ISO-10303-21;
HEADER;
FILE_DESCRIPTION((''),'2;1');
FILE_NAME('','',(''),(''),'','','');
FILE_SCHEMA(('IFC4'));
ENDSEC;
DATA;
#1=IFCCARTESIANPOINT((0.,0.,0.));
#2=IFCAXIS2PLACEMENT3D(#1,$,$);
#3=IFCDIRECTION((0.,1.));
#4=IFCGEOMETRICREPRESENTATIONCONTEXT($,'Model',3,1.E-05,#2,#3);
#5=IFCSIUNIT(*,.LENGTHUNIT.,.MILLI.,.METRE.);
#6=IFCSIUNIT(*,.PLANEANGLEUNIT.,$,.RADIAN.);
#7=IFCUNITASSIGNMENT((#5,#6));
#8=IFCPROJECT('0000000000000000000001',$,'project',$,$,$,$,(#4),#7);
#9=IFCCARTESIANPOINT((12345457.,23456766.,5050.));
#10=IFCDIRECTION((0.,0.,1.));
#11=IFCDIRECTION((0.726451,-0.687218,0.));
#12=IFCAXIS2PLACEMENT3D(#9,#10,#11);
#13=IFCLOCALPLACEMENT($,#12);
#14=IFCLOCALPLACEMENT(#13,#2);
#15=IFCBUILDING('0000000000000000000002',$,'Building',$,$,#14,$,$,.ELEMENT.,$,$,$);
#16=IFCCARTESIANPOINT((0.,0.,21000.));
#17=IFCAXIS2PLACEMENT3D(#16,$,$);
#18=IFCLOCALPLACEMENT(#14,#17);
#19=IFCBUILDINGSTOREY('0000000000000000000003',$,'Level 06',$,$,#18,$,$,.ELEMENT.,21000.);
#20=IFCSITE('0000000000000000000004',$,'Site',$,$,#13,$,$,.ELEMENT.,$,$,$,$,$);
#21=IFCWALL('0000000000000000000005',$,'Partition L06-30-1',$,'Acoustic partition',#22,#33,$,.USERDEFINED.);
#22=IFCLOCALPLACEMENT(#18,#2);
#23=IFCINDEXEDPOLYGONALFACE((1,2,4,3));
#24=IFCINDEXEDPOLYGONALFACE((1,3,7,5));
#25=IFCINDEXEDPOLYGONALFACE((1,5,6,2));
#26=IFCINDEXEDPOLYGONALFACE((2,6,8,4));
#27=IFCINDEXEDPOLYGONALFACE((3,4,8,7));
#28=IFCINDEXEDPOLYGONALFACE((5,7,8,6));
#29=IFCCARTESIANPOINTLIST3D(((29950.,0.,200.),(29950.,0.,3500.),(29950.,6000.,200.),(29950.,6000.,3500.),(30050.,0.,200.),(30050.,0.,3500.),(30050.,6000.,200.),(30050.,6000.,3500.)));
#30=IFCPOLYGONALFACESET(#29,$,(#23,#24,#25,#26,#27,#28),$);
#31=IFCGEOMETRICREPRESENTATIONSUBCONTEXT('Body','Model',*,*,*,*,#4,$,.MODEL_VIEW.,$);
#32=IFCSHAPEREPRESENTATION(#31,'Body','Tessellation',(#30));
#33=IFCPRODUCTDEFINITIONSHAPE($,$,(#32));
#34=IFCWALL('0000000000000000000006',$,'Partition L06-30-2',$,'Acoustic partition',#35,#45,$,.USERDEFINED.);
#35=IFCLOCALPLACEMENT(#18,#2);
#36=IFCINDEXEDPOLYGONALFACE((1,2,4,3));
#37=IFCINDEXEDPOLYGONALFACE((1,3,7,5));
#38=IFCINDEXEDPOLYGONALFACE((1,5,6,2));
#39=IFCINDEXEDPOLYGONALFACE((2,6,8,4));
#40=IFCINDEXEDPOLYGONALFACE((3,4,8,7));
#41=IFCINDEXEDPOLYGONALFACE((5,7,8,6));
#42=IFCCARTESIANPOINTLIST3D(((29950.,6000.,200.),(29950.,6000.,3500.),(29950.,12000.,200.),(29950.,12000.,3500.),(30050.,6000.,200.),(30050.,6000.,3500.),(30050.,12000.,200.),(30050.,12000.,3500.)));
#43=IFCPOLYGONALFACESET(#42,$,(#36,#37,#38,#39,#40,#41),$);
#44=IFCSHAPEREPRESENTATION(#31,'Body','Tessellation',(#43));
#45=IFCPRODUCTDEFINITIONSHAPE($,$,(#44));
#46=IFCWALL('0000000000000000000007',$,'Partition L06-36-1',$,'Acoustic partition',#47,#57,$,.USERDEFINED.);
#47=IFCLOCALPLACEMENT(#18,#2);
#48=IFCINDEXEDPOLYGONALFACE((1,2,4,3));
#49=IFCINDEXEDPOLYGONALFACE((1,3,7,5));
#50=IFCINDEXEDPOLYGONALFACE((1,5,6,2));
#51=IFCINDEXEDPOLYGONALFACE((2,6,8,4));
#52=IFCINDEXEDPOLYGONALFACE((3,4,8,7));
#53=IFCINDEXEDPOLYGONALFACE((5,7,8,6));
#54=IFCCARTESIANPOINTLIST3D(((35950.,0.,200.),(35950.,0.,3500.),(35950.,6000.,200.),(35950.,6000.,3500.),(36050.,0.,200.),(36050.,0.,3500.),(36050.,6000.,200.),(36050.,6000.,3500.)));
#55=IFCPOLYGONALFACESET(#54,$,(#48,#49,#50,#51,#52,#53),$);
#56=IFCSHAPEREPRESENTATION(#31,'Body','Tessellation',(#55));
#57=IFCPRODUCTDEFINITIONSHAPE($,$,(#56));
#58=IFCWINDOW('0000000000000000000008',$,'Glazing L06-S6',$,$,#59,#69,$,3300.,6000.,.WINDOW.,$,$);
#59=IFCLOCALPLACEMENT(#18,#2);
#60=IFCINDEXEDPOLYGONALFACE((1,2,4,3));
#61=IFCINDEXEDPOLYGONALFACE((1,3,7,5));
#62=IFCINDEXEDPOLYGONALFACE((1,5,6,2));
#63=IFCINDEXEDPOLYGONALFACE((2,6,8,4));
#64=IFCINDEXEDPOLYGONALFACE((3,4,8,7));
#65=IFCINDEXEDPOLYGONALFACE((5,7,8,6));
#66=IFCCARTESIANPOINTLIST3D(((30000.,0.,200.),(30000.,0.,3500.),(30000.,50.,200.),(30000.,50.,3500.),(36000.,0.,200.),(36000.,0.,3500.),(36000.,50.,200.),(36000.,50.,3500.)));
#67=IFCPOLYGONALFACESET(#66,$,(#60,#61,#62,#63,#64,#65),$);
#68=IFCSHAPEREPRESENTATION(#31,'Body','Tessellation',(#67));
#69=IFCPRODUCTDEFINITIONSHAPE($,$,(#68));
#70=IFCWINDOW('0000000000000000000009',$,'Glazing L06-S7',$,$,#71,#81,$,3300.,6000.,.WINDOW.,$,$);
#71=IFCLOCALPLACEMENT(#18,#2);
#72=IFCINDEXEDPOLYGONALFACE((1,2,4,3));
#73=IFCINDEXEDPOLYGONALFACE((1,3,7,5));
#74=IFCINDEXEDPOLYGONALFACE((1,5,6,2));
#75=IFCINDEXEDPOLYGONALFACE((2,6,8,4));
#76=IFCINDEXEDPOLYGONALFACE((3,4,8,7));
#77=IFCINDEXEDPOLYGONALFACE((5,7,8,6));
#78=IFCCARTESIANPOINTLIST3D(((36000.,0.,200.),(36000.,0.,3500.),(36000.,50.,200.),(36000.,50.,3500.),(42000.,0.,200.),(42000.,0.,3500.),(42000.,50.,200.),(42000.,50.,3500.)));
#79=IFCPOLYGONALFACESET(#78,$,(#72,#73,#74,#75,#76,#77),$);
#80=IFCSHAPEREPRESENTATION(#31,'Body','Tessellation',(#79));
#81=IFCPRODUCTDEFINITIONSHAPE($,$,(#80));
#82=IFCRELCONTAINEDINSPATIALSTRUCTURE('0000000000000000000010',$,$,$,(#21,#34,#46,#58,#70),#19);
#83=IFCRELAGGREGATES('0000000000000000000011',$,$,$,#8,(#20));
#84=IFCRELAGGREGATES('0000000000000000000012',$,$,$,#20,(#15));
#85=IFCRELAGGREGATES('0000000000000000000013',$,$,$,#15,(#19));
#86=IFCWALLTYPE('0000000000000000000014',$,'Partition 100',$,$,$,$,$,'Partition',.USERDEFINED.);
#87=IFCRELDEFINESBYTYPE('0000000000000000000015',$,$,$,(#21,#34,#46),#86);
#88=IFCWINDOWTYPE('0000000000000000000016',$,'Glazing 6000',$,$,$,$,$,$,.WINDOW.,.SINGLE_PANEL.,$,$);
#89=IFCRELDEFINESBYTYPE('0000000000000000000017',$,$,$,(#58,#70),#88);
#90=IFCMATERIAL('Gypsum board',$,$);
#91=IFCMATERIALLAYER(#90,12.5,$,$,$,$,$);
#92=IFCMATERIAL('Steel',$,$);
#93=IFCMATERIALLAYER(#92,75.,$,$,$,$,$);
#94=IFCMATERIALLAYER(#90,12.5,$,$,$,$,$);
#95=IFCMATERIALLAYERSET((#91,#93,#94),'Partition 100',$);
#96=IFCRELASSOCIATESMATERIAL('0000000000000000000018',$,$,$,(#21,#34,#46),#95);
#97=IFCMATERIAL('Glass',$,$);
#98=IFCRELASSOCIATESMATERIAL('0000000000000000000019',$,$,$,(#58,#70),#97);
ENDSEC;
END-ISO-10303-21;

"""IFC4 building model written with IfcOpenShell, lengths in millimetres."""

from ifc_helpers import new_model, si_unit, direction, frame, origin, place, context, subcontext, project, spatial, rectangle, extrude, material, layer, layer_set, layer_usage, type_object, element, save


model = new_model("IFC4")

# Units and contexts
model_context = context("Model", 3, precision=1e-05, world=origin(), true_north=direction((0.0, 1.0)))
body_context = subcontext(model_context, "Body", "Model", "MODEL_VIEW")
ifc_project = project(units=[si_unit("LENGTHUNIT", "METRE", prefix="MILLI"), si_unit("PLANEANGLEUNIT", "RADIAN")], contexts=[model_context])

# Site, building, storey
site_placement = place(None, frame((12345457.0, 23456766.0, 5050.0), z_axis=(0.0, 0.0, 1.0), x_axis=(0.726451, -0.687218, 0.0)))
site = spatial("IfcSite", under=ifc_project, at=site_placement, Name="Site", CompositionType="ELEMENT")
building_placement = place(site_placement, origin())
building = spatial("IfcBuilding", under=site, at=building_placement, Name="Building", CompositionType="ELEMENT")
storey_placement = place(building_placement, frame((0.0, 0.0, 21000.0)))
storey = spatial("IfcBuildingStorey", under=building, at=storey_placement, Name="Level 06", CompositionType="ELEMENT", Elevation=21000.0)

# Shared definitions
ifc_material_1 = material(Name="Steel")

# Walls
ifc_material_2 = material(Name="Gypsum board")
ifc_layer_1 = layer(ifc_material_2, 12.5)
ifc_layer_2 = layer(ifc_material_1, 75.0)
ifc_layer_3 = layer(ifc_material_2, 12.5)
ifc_layer_set = layer_set([ifc_layer_1, ifc_layer_2, ifc_layer_3], Name="Partition 100")
ifc_layer_usage = layer_usage(ifc_layer_set, "AXIS2", "POSITIVE", 0.0)
wall_type = type_object("IfcWallType", Name="Partition 100", ElementType="Partition", PredefinedType="USERDEFINED")
for number, where, name in (
    (1, (29950.0, 0.0, 200.0), "Partition L06-30-1"),
    (2, (29950.0, 6000.0, 200.0), "Partition L06-30-2"),
    (3, (35950.0, 0.0, 200.0), "Partition L06-36-1"),
):
    element("IfcWall", number, at=place(storey_placement, frame(where)), inside=storey, type_object=wall_type, material=ifc_layer_usage, Name=name, ObjectType="Acoustic partition", PredefinedType="USERDEFINED", context=body_context, shape_type="SweptSolid", body=[
        extrude(rectangle(XDim=100.0, YDim=6000.0), frame((50.0, 3000.0, 0.0)), (0.0, 0.0, 1.0), 3300.0),
    ])

# Windows
ifc_material_3 = material(Name="Glass")
window_type = type_object("IfcWindowType", Name="Glazing 6000", PartitioningType="SINGLE_PANEL", PredefinedType="WINDOW")
for number, where, name in (
    (4, (30000.0, 0.0, 200.0), "Glazing L06-S6"),
    (5, (36000.0, 0.0, 200.0), "Glazing L06-S7"),
):
    element("IfcWindow", number, at=place(storey_placement, frame(where)), inside=storey, type_object=window_type, material=ifc_material_3, Name=name, OverallHeight=3300.0, OverallWidth=6000.0, PredefinedType="WINDOW", context=body_context, shape_type="SweptSolid", body=[
        extrude(rectangle(XDim=6000.0, YDim=50.0), frame((3000.0, 25.0, 0.0)), (0.0, 0.0, 1.0), 3300.0),
    ])

save(model, "model.ifc")
